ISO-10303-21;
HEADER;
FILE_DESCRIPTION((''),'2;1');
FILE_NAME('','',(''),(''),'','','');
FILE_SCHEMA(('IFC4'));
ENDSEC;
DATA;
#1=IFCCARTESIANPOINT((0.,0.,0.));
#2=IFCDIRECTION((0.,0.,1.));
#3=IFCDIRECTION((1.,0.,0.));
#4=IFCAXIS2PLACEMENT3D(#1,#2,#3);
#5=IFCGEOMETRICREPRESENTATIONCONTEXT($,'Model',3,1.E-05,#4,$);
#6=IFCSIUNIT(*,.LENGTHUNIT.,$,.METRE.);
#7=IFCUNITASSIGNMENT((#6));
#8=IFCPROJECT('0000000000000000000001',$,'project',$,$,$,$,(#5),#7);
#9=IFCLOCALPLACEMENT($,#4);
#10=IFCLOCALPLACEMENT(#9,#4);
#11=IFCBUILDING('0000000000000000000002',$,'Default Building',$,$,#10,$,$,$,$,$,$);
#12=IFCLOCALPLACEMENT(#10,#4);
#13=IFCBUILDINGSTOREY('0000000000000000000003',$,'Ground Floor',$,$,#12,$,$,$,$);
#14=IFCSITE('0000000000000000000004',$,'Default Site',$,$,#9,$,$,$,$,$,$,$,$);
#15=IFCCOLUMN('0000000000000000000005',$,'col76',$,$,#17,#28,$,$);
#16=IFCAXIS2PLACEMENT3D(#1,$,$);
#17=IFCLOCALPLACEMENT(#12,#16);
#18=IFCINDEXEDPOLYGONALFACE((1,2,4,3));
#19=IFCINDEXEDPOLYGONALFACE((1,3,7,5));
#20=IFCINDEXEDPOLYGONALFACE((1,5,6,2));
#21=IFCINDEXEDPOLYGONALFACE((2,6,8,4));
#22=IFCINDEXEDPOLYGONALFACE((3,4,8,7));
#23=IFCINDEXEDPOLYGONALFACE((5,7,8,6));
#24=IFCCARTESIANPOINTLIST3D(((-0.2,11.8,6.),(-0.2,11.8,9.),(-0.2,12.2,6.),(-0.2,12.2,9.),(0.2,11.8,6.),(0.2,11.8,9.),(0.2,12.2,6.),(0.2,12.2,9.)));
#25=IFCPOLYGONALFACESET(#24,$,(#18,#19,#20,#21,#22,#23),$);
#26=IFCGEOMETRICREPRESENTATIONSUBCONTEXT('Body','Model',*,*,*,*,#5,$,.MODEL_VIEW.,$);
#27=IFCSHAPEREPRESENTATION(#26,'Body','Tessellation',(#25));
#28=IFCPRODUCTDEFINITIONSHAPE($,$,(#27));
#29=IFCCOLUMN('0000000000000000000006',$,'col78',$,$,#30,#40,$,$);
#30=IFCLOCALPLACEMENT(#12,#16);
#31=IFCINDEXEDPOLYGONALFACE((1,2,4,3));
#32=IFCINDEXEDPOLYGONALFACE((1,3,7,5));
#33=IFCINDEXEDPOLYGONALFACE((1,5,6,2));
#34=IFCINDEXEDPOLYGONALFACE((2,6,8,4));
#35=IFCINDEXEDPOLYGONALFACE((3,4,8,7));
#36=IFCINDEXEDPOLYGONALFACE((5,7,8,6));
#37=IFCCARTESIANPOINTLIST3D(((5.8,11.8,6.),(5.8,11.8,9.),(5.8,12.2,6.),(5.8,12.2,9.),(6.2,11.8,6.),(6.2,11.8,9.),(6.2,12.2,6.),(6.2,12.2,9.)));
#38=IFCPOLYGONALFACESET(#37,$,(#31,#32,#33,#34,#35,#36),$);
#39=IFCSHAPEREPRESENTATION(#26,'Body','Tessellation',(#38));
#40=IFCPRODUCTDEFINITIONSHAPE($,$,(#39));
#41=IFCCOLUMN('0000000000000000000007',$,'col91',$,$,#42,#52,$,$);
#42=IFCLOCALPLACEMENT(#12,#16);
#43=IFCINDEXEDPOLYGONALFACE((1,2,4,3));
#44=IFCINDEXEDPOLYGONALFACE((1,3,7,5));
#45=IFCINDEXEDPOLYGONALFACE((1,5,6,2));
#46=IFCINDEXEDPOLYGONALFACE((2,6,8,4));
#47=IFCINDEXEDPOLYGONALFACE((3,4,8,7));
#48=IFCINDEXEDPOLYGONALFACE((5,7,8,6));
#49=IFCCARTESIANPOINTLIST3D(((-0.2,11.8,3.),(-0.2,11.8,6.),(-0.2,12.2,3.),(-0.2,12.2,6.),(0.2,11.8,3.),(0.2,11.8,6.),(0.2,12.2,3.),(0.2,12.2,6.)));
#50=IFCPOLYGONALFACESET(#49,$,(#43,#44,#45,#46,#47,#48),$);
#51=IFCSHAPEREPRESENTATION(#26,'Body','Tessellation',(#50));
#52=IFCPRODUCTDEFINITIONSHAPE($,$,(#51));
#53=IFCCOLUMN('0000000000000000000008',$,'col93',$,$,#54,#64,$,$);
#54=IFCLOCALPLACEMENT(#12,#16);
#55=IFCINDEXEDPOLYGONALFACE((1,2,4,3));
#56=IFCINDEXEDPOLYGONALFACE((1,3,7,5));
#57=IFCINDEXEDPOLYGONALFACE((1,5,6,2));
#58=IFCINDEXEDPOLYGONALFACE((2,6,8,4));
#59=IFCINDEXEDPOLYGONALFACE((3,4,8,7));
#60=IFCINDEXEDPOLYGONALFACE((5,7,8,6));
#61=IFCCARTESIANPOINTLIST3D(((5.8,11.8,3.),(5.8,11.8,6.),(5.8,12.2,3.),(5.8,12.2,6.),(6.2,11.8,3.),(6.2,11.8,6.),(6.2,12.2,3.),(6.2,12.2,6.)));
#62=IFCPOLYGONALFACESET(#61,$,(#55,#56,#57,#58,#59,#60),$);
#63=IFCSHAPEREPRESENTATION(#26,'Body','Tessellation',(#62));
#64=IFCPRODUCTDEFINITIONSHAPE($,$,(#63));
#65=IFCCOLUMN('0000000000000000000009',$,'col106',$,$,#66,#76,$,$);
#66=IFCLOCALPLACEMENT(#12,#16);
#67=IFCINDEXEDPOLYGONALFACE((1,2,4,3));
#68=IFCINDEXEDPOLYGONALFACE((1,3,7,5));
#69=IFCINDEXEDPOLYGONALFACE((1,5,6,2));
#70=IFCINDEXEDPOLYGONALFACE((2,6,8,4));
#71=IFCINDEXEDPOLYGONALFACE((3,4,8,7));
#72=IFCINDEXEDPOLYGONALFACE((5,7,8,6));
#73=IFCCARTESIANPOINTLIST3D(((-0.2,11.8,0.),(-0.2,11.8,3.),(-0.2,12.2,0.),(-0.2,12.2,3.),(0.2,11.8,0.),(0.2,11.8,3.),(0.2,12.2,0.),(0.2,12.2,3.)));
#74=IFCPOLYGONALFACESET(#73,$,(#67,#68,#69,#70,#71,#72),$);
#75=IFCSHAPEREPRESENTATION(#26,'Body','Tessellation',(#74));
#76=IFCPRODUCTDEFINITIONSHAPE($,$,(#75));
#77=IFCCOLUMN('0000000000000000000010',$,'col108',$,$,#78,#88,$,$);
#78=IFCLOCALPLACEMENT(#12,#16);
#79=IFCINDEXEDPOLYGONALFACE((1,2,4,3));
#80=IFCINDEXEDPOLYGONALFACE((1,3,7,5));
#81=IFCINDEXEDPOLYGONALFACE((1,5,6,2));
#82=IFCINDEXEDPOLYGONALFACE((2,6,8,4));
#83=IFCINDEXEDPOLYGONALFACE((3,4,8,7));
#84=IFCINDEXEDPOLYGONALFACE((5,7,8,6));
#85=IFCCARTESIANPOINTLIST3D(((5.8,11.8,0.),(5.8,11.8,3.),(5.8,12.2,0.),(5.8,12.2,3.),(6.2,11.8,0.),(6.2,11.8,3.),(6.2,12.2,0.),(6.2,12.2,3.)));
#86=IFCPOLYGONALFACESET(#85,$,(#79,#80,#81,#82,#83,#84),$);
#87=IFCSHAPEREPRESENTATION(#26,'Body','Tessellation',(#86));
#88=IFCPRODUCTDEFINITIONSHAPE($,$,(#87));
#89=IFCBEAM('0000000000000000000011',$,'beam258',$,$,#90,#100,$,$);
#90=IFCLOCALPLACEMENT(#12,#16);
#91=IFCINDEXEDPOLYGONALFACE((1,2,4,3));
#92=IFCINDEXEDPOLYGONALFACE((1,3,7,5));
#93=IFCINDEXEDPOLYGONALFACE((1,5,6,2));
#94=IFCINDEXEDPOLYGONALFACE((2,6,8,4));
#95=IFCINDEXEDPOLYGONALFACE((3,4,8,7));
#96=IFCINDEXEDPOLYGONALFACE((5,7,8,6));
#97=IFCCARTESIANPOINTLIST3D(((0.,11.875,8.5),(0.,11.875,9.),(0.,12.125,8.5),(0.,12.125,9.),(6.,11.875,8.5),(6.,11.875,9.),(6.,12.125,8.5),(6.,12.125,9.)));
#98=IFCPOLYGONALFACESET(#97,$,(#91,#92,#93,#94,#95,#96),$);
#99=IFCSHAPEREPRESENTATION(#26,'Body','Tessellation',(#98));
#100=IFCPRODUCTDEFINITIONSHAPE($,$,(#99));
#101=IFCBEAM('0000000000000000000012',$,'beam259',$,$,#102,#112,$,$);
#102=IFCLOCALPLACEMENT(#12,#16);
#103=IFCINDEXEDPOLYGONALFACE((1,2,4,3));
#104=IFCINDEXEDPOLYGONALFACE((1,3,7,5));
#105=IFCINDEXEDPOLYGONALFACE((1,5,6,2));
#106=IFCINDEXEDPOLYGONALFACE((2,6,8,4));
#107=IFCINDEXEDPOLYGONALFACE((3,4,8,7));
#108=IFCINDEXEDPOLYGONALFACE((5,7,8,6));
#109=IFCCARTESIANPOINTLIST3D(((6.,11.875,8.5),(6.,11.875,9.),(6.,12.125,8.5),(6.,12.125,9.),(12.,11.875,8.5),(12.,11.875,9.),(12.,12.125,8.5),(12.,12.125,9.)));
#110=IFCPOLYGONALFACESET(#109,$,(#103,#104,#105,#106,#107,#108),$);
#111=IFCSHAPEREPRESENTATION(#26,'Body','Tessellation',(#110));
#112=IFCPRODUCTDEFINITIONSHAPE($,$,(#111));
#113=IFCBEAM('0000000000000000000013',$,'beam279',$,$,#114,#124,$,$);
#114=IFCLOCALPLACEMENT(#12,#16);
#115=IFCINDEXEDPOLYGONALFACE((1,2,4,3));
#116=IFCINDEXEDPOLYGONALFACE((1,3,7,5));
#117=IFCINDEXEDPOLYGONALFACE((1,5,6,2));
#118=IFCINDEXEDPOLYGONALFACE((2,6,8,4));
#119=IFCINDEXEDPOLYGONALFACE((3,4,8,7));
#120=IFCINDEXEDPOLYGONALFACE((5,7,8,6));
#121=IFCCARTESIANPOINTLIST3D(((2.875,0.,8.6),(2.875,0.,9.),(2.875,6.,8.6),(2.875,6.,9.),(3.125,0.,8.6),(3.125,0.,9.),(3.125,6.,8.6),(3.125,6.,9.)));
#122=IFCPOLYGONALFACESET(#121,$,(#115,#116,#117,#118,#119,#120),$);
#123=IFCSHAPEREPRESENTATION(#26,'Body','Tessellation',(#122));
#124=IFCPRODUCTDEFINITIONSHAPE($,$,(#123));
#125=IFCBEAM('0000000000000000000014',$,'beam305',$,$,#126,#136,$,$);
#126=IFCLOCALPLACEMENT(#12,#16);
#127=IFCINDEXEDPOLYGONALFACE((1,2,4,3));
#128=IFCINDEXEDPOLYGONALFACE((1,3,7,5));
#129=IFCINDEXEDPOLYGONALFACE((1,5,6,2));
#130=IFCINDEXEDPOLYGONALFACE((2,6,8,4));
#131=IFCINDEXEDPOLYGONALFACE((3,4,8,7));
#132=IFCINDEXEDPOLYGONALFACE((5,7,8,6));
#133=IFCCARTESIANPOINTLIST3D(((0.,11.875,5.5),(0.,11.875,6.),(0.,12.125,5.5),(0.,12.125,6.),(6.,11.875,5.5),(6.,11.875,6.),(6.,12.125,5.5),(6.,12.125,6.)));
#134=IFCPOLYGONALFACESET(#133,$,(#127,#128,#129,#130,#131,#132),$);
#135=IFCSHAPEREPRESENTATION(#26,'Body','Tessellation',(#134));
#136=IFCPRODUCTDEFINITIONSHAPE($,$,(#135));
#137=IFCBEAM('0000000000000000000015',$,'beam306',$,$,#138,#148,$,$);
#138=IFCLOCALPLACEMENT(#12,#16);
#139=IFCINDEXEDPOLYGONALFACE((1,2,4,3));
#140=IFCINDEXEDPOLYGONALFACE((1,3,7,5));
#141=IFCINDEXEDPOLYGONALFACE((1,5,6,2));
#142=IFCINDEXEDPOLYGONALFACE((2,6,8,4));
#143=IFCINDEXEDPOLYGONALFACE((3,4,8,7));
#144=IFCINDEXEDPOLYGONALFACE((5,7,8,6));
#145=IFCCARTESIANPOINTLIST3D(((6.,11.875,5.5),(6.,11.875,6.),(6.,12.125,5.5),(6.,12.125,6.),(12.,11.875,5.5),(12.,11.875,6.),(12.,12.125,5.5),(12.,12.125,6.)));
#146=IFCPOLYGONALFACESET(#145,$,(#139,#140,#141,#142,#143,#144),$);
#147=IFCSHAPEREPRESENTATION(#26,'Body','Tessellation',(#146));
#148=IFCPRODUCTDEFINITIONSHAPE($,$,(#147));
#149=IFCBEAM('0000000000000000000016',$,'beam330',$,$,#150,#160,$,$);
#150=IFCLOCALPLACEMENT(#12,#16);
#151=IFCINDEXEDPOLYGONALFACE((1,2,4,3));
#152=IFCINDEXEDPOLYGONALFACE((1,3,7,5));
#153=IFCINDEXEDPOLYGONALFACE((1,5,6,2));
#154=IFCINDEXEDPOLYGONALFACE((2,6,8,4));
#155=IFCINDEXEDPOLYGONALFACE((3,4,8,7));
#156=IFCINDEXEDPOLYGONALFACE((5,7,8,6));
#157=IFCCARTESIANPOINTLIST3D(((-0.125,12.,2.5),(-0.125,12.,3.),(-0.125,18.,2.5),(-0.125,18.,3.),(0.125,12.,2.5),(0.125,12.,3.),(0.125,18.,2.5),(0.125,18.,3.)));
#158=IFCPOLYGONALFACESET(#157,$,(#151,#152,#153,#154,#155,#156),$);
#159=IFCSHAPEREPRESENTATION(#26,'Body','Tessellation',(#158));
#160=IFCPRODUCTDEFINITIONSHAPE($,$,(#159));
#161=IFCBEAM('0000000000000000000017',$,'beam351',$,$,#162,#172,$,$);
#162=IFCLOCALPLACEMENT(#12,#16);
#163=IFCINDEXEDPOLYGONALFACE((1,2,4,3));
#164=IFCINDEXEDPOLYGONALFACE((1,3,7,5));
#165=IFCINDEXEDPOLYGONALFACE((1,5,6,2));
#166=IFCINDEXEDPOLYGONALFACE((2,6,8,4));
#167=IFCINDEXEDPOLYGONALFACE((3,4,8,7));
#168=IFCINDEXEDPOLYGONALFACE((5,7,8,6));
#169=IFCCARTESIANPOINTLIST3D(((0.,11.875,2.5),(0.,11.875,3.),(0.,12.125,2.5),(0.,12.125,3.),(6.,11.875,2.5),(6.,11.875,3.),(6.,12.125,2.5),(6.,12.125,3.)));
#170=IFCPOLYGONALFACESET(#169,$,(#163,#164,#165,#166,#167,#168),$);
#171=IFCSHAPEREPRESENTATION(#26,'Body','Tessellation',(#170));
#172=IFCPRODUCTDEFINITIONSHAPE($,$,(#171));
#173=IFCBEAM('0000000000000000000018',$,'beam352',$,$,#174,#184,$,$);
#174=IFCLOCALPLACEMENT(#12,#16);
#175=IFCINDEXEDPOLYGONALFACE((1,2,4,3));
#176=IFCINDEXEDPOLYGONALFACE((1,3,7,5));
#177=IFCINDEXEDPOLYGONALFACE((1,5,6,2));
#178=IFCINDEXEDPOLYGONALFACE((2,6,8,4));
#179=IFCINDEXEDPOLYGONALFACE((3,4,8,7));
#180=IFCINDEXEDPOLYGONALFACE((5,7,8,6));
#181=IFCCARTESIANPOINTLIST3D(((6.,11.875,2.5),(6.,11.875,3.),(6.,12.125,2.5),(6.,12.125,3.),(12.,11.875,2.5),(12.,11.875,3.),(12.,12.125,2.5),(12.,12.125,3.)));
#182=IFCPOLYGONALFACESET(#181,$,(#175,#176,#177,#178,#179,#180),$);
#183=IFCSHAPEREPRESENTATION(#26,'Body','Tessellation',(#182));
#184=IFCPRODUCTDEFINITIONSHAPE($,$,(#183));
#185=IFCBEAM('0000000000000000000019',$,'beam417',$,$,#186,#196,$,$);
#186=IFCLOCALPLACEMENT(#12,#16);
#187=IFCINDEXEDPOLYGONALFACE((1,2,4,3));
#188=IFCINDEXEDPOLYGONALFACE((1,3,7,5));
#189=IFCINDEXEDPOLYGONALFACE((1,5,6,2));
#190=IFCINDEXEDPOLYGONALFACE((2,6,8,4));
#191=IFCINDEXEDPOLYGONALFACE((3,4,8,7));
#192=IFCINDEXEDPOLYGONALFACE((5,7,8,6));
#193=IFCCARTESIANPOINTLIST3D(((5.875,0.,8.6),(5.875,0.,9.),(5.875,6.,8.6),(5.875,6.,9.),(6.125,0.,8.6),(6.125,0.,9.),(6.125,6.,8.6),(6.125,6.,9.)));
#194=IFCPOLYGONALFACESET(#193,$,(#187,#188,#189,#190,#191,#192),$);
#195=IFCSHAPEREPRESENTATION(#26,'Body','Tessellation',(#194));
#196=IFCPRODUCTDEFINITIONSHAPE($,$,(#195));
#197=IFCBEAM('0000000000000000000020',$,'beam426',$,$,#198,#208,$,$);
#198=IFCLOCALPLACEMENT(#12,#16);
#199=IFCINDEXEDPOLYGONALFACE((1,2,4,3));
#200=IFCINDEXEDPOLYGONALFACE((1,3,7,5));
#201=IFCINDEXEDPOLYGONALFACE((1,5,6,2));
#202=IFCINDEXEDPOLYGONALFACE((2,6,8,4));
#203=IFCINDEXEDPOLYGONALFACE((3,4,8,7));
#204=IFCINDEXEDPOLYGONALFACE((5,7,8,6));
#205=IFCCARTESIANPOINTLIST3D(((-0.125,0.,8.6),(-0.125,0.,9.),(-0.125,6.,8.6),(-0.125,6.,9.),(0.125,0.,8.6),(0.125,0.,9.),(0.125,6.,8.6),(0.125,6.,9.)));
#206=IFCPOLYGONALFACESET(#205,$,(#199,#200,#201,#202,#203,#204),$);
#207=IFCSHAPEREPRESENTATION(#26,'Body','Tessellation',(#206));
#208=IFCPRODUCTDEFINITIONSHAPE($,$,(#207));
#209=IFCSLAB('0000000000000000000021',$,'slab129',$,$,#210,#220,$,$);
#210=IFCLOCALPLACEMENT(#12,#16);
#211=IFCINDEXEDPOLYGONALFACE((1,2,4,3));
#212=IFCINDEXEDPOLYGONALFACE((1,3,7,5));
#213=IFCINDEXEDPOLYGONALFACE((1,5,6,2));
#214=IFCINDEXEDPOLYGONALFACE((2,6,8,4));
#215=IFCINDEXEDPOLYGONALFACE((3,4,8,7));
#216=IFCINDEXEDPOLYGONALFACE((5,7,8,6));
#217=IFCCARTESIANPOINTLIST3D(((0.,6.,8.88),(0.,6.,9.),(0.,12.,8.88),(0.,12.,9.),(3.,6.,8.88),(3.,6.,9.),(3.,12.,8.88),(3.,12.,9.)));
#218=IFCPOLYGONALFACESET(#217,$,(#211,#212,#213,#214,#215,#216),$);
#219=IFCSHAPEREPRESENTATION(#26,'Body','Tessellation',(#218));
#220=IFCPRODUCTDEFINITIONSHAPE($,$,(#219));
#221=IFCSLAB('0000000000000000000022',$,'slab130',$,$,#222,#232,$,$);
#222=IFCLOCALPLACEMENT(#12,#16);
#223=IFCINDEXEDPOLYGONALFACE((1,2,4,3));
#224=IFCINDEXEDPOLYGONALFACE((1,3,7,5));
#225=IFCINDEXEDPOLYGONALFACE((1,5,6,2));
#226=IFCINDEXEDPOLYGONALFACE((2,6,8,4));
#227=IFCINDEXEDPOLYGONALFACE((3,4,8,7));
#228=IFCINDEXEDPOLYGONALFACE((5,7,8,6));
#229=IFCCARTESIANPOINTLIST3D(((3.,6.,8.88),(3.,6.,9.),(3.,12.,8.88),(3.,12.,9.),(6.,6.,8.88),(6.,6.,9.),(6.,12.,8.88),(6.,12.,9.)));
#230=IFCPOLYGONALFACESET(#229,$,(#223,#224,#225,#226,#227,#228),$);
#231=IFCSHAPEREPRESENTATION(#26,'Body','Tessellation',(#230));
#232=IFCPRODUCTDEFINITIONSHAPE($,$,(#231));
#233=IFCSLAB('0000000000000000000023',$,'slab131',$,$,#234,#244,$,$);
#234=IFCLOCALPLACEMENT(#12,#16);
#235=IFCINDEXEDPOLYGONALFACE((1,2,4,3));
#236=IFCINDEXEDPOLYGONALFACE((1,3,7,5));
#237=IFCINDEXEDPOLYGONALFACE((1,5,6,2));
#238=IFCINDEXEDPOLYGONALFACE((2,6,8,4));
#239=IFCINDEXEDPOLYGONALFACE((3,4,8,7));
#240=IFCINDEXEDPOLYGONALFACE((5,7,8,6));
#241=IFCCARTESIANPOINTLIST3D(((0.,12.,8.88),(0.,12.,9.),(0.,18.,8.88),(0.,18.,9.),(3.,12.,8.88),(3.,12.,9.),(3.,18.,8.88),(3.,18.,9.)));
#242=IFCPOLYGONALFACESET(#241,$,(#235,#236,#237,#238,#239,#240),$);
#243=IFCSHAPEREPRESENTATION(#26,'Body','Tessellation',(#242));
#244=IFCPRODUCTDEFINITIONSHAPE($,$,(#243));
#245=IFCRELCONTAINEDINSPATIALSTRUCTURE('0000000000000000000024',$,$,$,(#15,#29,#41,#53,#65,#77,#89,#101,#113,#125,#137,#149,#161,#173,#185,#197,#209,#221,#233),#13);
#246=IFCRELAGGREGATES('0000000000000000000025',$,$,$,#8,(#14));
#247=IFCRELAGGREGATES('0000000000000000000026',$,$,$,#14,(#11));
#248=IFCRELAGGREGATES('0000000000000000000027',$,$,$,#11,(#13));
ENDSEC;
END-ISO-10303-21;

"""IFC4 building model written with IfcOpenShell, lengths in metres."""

from ifc_helpers import new_model, si_unit, frame, origin_with_axes, place, context, subcontext, project, spatial, indexed_curve, outline, extrude, element, save


model = new_model("IFC4")

# Units and contexts
model_context = context("Model", 3, precision=1e-05, world=origin_with_axes())
body_context = subcontext(model_context, "Body", "Model", "MODEL_VIEW")
ifc_project = project(units=[si_unit("LENGTHUNIT", "METRE")], contexts=[model_context])

# Site, building, storey
site_placement = place(None, origin_with_axes())
site = spatial("IfcSite", under=ifc_project, at=site_placement, Name="Default Site")
building_placement = place(site_placement, origin_with_axes())
building = spatial("IfcBuilding", under=site, at=building_placement, Name="Default Building")
storey_placement = place(building_placement, origin_with_axes())
storey = spatial("IfcBuildingStorey", under=building, at=storey_placement, Name="Ground Floor")

# Columns
for number, where, z_axis, x_axis, name in (
    (1, (-0.2, 11.8, 6.0), (0.0, 0.0, 1.0), (1.0, 0.0, 0.0), "col76"),
    (2, (5.8, 11.8, 6.0), (0.0, 0.0, 1.0), (1.0, 0.0, 0.0), "col78"),
    (3, (-0.2, 11.8, 3.0), (0.0, 0.0, 1.0), (1.0, 0.0, 0.0), "col91"),
    (4, (5.8, 11.8, 3.0), (0.0, 0.0, 1.0), (1.0, 0.0, 0.0), "col93"),
    (5, (-0.2, 11.8, 0.0), (0.0, 0.0, 1.0), (1.0, 0.0, 0.0), "col106"),
    (6, (5.8, 11.8, 0.0), (0.0, 0.0, 1.0), (1.0, 0.0, 0.0), "col108"),
):
    element("IfcColumn", number, at=place(storey_placement, frame(where, z_axis=z_axis, x_axis=x_axis)), inside=storey, Name=name, context=body_context, shape_type="SweptSolid", body=[
        extrude(outline(indexed_curve([(0.0, 0.0), (0.0, 0.4), (0.4, 0.4), (0.4, 0.0), (0.0, 0.0)], self_intersect=False)), origin_with_axes(), (0.0, 0.0, 1.0), 3.0),
    ])

# Beams
for number, where, z_axis, x_axis, name in (
    (7, (0.0, 11.875, 8.5), (0.0, 0.0, 1.0), (1.0, 0.0, 0.0), "beam258"),
    (8, (6.0, 11.875, 8.5), (0.0, 0.0, 1.0), (1.0, 0.0, 0.0), "beam259"),
):
    element("IfcBeam", number, at=place(storey_placement, frame(where, z_axis=z_axis, x_axis=x_axis)), inside=storey, Name=name, context=body_context, shape_type="SweptSolid", body=[
        extrude(outline(indexed_curve([(0.0, 0.0), (0.0, 0.25), (6.0, 0.25), (6.0, 0.0), (0.0, 0.0)], self_intersect=False)), origin_with_axes(), (0.0, 0.0, 1.0), 0.5),
    ])
beam_placement = place(storey_placement, frame((2.875, 6.0, 8.6), z_axis=(0.0, 0.0, 1.0), x_axis=(0.0, -1.0, 0.0)))
element("IfcBeam", 9, at=beam_placement, inside=storey, Name="beam279", context=body_context, shape_type="SweptSolid", body=[
    extrude(outline(indexed_curve([(0.0, 0.0), (0.0, 0.25), (6.0, 0.25), (6.0, 0.0), (0.0, 0.0)], self_intersect=False)), origin_with_axes(), (0.0, 0.0, 1.0), 0.4),
])
for number, where, z_axis, x_axis, name in (
    (10, (0.0, 11.875, 5.5), (0.0, 0.0, 1.0), (1.0, 0.0, 0.0), "beam305"),
    (11, (6.0, 11.875, 5.5), (0.0, 0.0, 1.0), (1.0, 0.0, 0.0), "beam306"),
    (12, (0.125, 12.0, 2.5), (0.0, 0.0, 1.0), (0.0, 1.0, 0.0), "beam330"),
    (13, (0.0, 11.875, 2.5), (0.0, 0.0, 1.0), (1.0, 0.0, 0.0), "beam351"),
    (14, (6.0, 11.875, 2.5), (0.0, 0.0, 1.0), (1.0, 0.0, 0.0), "beam352"),
):
    element("IfcBeam", number, at=place(storey_placement, frame(where, z_axis=z_axis, x_axis=x_axis)), inside=storey, Name=name, context=body_context, shape_type="SweptSolid", body=[
        extrude(outline(indexed_curve([(0.0, 0.0), (0.0, 0.25), (6.0, 0.25), (6.0, 0.0), (0.0, 0.0)], self_intersect=False)), origin_with_axes(), (0.0, 0.0, 1.0), 0.5),
    ])
for number, where, z_axis, x_axis, name in (
    (15, (5.875, 6.0, 8.6), (0.0, 0.0, 1.0), (0.0, -1.0, 0.0), "beam417"),
    (16, (-0.125, 6.0, 8.6), (0.0, 0.0, 1.0), (0.0, -1.0, 0.0), "beam426"),
):
    element("IfcBeam", number, at=place(storey_placement, frame(where, z_axis=z_axis, x_axis=x_axis)), inside=storey, Name=name, context=body_context, shape_type="SweptSolid", body=[
        extrude(outline(indexed_curve([(0.0, 0.0), (0.0, 0.25), (6.0, 0.25), (6.0, 0.0), (0.0, 0.0)], self_intersect=False)), origin_with_axes(), (0.0, 0.0, 1.0), 0.4),
    ])

# Slabs
for number, where, z_axis, x_axis, name in (
    (17, (0.0, 6.0, 8.88), (0.0, 0.0, 1.0), (1.0, 0.0, 0.0), "slab129"),
    (18, (3.0, 6.0, 8.88), (0.0, 0.0, 1.0), (1.0, 0.0, 0.0), "slab130"),
    (19, (0.0, 12.0, 8.88), (0.0, 0.0, 1.0), (1.0, 0.0, 0.0), "slab131"),
):
    element("IfcSlab", number, at=place(storey_placement, frame(where, z_axis=z_axis, x_axis=x_axis)), inside=storey, Name=name, context=body_context, shape_type="SweptSolid", body=[
        extrude(outline(indexed_curve([(0.0, 0.0), (0.0, 6.0), (3.0, 6.0), (3.0, 0.0), (0.0, 0.0)], self_intersect=False)), origin_with_axes(), (0.0, 0.0, 1.0), 0.12),
    ])

save(model, "model.ifc")
